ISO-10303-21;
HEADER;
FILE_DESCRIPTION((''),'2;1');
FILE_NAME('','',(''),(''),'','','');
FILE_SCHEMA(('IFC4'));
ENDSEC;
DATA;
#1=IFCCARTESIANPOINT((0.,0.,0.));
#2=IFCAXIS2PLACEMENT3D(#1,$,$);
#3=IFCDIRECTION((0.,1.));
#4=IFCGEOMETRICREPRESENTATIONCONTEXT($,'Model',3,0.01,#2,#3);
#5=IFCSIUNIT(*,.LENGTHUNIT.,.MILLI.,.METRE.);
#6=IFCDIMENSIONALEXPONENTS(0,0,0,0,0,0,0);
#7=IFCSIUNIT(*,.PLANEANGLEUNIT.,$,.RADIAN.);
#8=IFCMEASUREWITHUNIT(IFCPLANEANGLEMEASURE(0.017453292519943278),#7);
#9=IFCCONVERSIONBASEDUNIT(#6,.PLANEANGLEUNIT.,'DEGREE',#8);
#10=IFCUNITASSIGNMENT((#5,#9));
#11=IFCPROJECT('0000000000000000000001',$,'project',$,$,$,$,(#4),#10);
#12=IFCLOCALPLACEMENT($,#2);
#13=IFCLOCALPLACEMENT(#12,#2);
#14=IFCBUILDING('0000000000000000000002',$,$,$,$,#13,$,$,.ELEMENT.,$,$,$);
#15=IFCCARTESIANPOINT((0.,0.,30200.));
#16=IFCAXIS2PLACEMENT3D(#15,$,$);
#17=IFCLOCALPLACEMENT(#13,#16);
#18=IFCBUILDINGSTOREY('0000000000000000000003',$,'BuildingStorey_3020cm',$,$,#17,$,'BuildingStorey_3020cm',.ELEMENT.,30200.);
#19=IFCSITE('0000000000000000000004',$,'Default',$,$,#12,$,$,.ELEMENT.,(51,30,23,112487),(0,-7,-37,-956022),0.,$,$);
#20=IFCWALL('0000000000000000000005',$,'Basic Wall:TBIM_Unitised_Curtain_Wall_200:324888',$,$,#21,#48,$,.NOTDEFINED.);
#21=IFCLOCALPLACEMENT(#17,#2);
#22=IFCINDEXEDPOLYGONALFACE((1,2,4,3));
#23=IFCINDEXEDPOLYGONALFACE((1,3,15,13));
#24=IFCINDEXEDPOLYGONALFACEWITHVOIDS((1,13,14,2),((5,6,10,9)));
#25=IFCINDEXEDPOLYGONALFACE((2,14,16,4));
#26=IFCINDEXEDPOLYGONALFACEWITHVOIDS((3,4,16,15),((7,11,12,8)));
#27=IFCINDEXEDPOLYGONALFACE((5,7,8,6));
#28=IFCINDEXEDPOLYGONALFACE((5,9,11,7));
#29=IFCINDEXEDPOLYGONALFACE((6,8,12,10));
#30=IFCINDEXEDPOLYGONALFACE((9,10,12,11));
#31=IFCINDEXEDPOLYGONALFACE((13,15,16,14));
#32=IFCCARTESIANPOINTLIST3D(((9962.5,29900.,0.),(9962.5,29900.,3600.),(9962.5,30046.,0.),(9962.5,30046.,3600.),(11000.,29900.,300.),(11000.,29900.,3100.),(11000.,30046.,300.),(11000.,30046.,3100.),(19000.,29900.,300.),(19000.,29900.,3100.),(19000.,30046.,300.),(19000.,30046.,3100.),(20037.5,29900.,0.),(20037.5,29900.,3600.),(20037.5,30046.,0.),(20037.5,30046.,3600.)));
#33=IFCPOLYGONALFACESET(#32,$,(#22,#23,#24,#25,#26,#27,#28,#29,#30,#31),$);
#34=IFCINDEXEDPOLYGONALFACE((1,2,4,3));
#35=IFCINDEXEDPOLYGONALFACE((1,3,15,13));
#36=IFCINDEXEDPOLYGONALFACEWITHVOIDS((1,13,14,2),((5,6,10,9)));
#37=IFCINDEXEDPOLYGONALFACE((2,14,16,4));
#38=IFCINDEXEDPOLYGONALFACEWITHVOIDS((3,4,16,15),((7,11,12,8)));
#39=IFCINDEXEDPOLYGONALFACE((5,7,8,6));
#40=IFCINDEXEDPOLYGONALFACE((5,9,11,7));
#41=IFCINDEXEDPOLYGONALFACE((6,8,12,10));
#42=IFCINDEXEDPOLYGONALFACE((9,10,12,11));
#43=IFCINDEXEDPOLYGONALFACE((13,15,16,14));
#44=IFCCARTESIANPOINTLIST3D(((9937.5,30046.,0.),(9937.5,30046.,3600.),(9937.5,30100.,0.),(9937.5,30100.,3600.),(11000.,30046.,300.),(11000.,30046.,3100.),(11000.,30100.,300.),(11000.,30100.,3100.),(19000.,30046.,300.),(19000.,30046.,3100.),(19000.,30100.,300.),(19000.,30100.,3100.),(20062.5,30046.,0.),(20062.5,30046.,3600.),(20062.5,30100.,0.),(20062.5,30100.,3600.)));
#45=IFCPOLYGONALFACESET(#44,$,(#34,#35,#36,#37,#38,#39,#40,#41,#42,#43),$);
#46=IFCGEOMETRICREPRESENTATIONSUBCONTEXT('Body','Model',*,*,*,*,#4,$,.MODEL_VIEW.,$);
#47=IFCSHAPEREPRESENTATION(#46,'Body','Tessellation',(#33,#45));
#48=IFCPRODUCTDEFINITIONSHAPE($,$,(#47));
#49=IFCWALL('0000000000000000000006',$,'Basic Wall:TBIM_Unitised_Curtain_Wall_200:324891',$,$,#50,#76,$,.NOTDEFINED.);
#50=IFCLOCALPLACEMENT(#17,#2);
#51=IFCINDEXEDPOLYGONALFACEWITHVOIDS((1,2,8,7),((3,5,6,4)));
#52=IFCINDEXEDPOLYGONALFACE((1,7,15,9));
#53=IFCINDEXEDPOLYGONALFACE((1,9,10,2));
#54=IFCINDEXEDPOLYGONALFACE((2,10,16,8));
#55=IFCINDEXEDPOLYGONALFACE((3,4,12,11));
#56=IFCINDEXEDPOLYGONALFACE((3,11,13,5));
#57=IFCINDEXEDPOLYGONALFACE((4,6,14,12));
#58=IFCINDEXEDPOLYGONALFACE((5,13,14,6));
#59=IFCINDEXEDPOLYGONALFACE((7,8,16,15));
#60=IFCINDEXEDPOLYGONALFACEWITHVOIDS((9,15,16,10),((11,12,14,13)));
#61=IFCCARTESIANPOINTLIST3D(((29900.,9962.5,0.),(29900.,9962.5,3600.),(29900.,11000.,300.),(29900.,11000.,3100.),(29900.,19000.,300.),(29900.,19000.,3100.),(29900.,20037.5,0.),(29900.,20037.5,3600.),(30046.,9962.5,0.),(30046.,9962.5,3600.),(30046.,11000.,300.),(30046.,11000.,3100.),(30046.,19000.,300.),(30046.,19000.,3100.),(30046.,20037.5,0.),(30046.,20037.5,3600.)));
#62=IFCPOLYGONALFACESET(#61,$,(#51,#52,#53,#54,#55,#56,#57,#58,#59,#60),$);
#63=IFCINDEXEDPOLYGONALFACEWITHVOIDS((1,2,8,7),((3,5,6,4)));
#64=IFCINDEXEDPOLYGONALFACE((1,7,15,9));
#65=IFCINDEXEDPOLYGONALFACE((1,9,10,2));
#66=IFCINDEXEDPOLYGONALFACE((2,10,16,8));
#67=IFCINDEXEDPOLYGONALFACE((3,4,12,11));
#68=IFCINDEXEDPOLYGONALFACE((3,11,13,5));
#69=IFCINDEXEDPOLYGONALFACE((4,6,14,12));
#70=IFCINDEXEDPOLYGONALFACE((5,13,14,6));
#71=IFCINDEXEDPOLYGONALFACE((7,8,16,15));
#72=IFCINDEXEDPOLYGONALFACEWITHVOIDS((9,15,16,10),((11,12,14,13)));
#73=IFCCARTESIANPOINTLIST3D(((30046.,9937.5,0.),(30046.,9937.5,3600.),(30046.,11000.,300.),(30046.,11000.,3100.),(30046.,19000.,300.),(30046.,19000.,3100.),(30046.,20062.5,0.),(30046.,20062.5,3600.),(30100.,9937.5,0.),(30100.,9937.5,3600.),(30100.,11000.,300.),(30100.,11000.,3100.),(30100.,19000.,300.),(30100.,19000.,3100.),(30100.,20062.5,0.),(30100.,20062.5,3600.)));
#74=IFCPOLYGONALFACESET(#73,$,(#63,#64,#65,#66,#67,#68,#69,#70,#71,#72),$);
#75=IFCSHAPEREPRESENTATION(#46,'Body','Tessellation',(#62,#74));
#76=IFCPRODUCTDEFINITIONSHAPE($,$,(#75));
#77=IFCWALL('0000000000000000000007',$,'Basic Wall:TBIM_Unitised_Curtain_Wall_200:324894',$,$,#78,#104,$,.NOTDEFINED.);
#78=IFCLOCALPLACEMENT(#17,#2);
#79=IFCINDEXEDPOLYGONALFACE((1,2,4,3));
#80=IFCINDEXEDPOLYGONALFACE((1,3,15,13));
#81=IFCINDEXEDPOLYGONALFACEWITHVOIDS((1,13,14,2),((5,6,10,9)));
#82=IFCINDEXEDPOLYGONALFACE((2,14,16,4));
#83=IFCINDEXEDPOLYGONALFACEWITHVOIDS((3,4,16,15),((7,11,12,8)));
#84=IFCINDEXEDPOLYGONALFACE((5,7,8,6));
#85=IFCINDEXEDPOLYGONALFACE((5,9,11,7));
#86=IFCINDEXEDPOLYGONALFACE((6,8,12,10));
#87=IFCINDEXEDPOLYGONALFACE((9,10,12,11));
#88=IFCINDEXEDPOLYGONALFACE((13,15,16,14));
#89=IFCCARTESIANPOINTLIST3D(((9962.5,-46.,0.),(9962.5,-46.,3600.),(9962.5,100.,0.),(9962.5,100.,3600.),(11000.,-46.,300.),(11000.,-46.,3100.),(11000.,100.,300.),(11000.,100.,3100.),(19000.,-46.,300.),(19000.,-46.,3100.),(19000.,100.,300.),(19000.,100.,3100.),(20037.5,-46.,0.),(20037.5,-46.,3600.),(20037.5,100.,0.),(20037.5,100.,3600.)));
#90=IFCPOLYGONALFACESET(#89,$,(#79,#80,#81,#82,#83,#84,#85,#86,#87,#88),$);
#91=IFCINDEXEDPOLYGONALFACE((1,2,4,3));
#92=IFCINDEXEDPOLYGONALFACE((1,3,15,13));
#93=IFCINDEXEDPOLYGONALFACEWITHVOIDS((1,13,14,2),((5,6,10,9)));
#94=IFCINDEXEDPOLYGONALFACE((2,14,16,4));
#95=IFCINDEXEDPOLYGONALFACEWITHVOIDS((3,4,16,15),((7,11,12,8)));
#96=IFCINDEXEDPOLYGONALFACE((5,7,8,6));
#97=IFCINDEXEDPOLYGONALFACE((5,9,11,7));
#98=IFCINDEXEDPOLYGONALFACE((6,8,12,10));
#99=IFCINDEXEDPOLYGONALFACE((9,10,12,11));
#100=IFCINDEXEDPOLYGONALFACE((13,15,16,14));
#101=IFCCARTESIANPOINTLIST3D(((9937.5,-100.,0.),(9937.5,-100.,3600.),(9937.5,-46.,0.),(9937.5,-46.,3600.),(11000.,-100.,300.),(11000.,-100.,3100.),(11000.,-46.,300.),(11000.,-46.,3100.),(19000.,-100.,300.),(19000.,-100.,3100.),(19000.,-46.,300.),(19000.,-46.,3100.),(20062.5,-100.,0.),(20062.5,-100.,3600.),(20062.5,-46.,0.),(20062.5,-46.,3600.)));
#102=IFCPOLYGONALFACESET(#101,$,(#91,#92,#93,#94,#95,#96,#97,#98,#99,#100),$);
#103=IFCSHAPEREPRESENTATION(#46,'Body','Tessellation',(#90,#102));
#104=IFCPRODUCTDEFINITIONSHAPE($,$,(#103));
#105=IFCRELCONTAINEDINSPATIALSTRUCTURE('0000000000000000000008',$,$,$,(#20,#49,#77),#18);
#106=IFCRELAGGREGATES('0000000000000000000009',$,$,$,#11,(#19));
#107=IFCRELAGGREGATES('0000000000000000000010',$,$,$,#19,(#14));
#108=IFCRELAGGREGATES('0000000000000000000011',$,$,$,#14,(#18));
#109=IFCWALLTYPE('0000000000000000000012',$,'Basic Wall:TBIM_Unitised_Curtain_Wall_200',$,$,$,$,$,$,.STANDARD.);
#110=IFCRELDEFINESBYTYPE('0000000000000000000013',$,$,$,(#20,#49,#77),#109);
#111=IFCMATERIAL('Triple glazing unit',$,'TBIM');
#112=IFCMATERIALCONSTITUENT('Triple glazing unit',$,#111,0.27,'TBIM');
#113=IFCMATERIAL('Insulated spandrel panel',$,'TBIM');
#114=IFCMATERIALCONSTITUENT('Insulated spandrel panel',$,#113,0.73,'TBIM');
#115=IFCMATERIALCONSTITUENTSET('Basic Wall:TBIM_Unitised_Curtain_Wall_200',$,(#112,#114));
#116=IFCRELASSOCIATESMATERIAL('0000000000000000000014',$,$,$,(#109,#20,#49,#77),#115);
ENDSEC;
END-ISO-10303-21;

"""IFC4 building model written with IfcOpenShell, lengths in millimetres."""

from ifc_helpers import new_model, entity, si_unit, converted_unit, direction, frame, origin, place, context, subcontext, project, spatial, indexed_curve, outline, extrude, material, constituent, constituent_set, type_object, element, save


model = new_model("IFC4")

# Units and contexts
model_context = context("Model", 3, precision=0.01, world=origin(), true_north=direction((0.0, 1.0)))
body_context = subcontext(model_context, "Body", "Model", "MODEL_VIEW")
ifc_project = project(units=[si_unit("LENGTHUNIT", "METRE", prefix="MILLI"), converted_unit("PLANEANGLEUNIT", "DEGREE", entity("IfcPlaneAngleMeasure", 0.017453292519943278), si_unit("PLANEANGLEUNIT", "RADIAN"), dimensions=[0, 0, 0, 0, 0, 0, 0])], contexts=[model_context])

# Site, building, storey
site_placement = place(None, origin())
site = spatial("IfcSite", under=ifc_project, at=site_placement, Name="Default", CompositionType="ELEMENT", RefLatitude=(51, 30, 23, 112487), RefLongitude=(0, -7, -37, -956022), RefElevation=0.0)
building_placement = place(site_placement, origin())
building = spatial("IfcBuilding", under=site, at=building_placement, CompositionType="ELEMENT")
storey_placement = place(building_placement, frame((0.0, 0.0, 30200.0)))
storey = spatial("IfcBuildingStorey", under=building, at=storey_placement, Name="BuildingStorey_3020cm", LongName="BuildingStorey_3020cm", CompositionType="ELEMENT", Elevation=30200.0)

# Walls, openings
ifc_material_1 = material(Name="Triple glazing unit", Category="TBIM")
ifc_constituent_1 = constituent(ifc_material_1, Name="Triple glazing unit", Category="TBIM", fraction=0.27)
ifc_material_2 = material(Name="Insulated spandrel panel", Category="TBIM")
ifc_constituent_2 = constituent(ifc_material_2, Name="Insulated spandrel panel", Category="TBIM", fraction=0.73)
ifc_constituent_set_1 = constituent_set(constituents=[ifc_constituent_1, ifc_constituent_2], Name="Basic Wall:TBIM_Unitised_Curtain_Wall_200")
wall_type_1 = type_object("IfcWallType", Name="Basic Wall:TBIM_Unitised_Curtain_Wall_200", PredefinedType="STANDARD", material=ifc_constituent_set_1)
wall_1_placement = place(storey_placement, frame((9937.5, 30000.0, 0.0)))
wall_1 = element("IfcWall", 1, at=wall_1_placement, inside=storey, type_object=wall_type_1, material=ifc_constituent_set_1, Name="Basic Wall:TBIM_Unitised_Curtain_Wall_200:324888", PredefinedType="NOTDEFINED", context=body_context, shape_type="SweptSolid", body=[
    extrude(outline(indexed_curve([(-1800.0, -5037.5), (1800.0, -5037.5), (1800.0, -4937.5), (1800.0, 4937.5), (1800.0, 5037.5), (-1800.0, 5037.5), (-1800.0, 4937.5), (-1800.0, -4937.5), (-1800.0, -5037.5)], self_intersect=False), holes=[indexed_curve([(1300.0, -4000.0), (-1500.0, -4000.0), (-1500.0, 4000.0), (1300.0, 4000.0), (1300.0, -4000.0)], self_intersect=False)]), frame((5062.5, -100.0, 1800.0), z_axis=(0.0, 1.0, 0.0), x_axis=(0.0, 0.0, 1.0)), (0.0, 0.0, 1.0), 146.0),
    extrude(outline(indexed_curve([(-1800.0, -5062.5), (1800.0, -5062.5), (1800.0, 5062.5), (-1800.0, 5062.5), (-1800.0, -5062.5)], self_intersect=False), holes=[indexed_curve([(-1500.0, -4000.0), (-1500.0, 4000.0), (1300.0, 4000.0), (1300.0, -4000.0), (-1500.0, -4000.0)], self_intersect=False)]), frame((5062.5, 46.0, 1800.0), z_axis=(0.0, 1.0, 0.0), x_axis=(0.0, 0.0, 1.0)), (0.0, 0.0, 1.0), 54.0),
])
opening_1_placement = place(wall_1_placement, frame((1062.5, -100.0, 300.0)))
element("IfcOpeningElement", 2, at=opening_1_placement, cuts=wall_1, PredefinedType="OPENING", context=body_context, shape_type="SweptSolid", body=[
    extrude(outline(indexed_curve([(2800.0, 0.0), (2800.0, 8000.0), (0.0, 8000.0), (0.0, 0.0), (2800.0, 0.0)], self_intersect=False)), frame((0.0, 0.0, 0.0), z_axis=(0.0, 1.0, 0.0), x_axis=(0.0, 0.0, 1.0)), (0.0, 0.0, 1.0), 200.0),
])
wall_2_placement = place(storey_placement, frame((30000.0, 9937.5, 0.0), z_axis=(0.0, 0.0, 1.0), x_axis=(0.0, 1.0, 0.0)))
wall_2 = element("IfcWall", 3, at=wall_2_placement, inside=storey, type_object=wall_type_1, material=ifc_constituent_set_1, Name="Basic Wall:TBIM_Unitised_Curtain_Wall_200:324891", PredefinedType="NOTDEFINED", context=body_context, shape_type="SweptSolid", body=[
    extrude(outline(indexed_curve([(-5037.5, -1800.0), (-4937.5, -1800.0), (4937.5, -1800.0), (5037.5, -1800.0), (5037.5, 1800.0), (4937.5, 1800.0), (-4937.5, 1800.0), (-5037.5, 1800.0), (-5037.5, -1800.0)], self_intersect=False), holes=[indexed_curve([(-4000.0, 1300.0), (4000.0, 1300.0), (4000.0, -1500.0), (-4000.0, -1500.0), (-4000.0, 1300.0)], self_intersect=False)]), frame((5062.5, 100.0, 1800.0), z_axis=(0.0, -1.0, 0.0), x_axis=(1.0, 0.0, 0.0)), (0.0, 0.0, 1.0), 146.0),
    extrude(outline(indexed_curve([(-1800.0, -5062.5), (1800.0, -5062.5), (1800.0, 5062.5), (-1800.0, 5062.5), (-1800.0, -5062.5)], self_intersect=False), holes=[indexed_curve([(1300.0, 4000.0), (1300.0, -4000.0), (-1500.0, -4000.0), (-1500.0, 4000.0), (1300.0, 4000.0)], self_intersect=False)]), frame((5062.5, -46.0, 1800.0), z_axis=(0.0, -1.0, 0.0), x_axis=(0.0, 0.0, 1.0)), (0.0, 0.0, 1.0), 54.0),
])
opening_2_placement = place(wall_2_placement, frame((1062.5, -100.0, 300.0)))
element("IfcOpeningElement", 4, at=opening_2_placement, cuts=wall_2, PredefinedType="OPENING", context=body_context, shape_type="SweptSolid", body=[
    extrude(outline(indexed_curve([(2800.0, 0.0), (2800.0, 8000.0), (0.0, 8000.0), (0.0, 0.0), (2800.0, 0.0)], self_intersect=False)), frame((0.0, 0.0, 0.0), z_axis=(0.0, 1.0, 0.0), x_axis=(0.0, 0.0, 1.0)), (0.0, 0.0, 1.0), 200.0),
])
wall_3_placement = place(storey_placement, frame((9937.5, 0.0, 0.0)))
wall_3 = element("IfcWall", 5, at=wall_3_placement, inside=storey, type_object=wall_type_1, material=ifc_constituent_set_1, Name="Basic Wall:TBIM_Unitised_Curtain_Wall_200:324894", PredefinedType="NOTDEFINED", context=body_context, shape_type="SweptSolid", body=[
    extrude(outline(indexed_curve([(-1800.0, -5037.5), (1800.0, -5037.5), (1800.0, 5037.5), (-1800.0, 5037.5), (-1800.0, -5037.5)], self_intersect=False), holes=[indexed_curve([(-1500.0, -4000.0), (-1500.0, 4000.0), (1300.0, 4000.0), (1300.0, -4000.0), (-1500.0, -4000.0)], self_intersect=False)]), frame((5062.5, -46.0, 1800.0), z_axis=(0.0, 1.0, 0.0), x_axis=(0.0, 0.0, 1.0)), (0.0, 0.0, 1.0), 146.0),
    extrude(outline(indexed_curve([(-1800.0, -5062.5), (1800.0, -5062.5), (1800.0, 5062.5), (-1800.0, 5062.5), (-1800.0, -5062.5)], self_intersect=False), holes=[indexed_curve([(1300.0, -4000.0), (-1500.0, -4000.0), (-1500.0, 4000.0), (1300.0, 4000.0), (1300.0, -4000.0)], self_intersect=False)]), frame((5062.5, -100.0, 1800.0), z_axis=(0.0, 1.0, 0.0), x_axis=(0.0, 0.0, 1.0)), (0.0, 0.0, 1.0), 54.0),
])
opening_3_placement = place(wall_3_placement, frame((1062.5, -100.0, 300.0)))
element("IfcOpeningElement", 6, at=opening_3_placement, cuts=wall_3, PredefinedType="OPENING", context=body_context, shape_type="SweptSolid", body=[
    extrude(outline(indexed_curve([(2800.0, 0.0), (2800.0, 8000.0), (0.0, 8000.0), (0.0, 0.0), (2800.0, 0.0)], self_intersect=False)), frame((0.0, 0.0, 0.0), z_axis=(0.0, 1.0, 0.0), x_axis=(0.0, 0.0, 1.0)), (0.0, 0.0, 1.0), 200.0),
])

save(model, "model.ifc")
